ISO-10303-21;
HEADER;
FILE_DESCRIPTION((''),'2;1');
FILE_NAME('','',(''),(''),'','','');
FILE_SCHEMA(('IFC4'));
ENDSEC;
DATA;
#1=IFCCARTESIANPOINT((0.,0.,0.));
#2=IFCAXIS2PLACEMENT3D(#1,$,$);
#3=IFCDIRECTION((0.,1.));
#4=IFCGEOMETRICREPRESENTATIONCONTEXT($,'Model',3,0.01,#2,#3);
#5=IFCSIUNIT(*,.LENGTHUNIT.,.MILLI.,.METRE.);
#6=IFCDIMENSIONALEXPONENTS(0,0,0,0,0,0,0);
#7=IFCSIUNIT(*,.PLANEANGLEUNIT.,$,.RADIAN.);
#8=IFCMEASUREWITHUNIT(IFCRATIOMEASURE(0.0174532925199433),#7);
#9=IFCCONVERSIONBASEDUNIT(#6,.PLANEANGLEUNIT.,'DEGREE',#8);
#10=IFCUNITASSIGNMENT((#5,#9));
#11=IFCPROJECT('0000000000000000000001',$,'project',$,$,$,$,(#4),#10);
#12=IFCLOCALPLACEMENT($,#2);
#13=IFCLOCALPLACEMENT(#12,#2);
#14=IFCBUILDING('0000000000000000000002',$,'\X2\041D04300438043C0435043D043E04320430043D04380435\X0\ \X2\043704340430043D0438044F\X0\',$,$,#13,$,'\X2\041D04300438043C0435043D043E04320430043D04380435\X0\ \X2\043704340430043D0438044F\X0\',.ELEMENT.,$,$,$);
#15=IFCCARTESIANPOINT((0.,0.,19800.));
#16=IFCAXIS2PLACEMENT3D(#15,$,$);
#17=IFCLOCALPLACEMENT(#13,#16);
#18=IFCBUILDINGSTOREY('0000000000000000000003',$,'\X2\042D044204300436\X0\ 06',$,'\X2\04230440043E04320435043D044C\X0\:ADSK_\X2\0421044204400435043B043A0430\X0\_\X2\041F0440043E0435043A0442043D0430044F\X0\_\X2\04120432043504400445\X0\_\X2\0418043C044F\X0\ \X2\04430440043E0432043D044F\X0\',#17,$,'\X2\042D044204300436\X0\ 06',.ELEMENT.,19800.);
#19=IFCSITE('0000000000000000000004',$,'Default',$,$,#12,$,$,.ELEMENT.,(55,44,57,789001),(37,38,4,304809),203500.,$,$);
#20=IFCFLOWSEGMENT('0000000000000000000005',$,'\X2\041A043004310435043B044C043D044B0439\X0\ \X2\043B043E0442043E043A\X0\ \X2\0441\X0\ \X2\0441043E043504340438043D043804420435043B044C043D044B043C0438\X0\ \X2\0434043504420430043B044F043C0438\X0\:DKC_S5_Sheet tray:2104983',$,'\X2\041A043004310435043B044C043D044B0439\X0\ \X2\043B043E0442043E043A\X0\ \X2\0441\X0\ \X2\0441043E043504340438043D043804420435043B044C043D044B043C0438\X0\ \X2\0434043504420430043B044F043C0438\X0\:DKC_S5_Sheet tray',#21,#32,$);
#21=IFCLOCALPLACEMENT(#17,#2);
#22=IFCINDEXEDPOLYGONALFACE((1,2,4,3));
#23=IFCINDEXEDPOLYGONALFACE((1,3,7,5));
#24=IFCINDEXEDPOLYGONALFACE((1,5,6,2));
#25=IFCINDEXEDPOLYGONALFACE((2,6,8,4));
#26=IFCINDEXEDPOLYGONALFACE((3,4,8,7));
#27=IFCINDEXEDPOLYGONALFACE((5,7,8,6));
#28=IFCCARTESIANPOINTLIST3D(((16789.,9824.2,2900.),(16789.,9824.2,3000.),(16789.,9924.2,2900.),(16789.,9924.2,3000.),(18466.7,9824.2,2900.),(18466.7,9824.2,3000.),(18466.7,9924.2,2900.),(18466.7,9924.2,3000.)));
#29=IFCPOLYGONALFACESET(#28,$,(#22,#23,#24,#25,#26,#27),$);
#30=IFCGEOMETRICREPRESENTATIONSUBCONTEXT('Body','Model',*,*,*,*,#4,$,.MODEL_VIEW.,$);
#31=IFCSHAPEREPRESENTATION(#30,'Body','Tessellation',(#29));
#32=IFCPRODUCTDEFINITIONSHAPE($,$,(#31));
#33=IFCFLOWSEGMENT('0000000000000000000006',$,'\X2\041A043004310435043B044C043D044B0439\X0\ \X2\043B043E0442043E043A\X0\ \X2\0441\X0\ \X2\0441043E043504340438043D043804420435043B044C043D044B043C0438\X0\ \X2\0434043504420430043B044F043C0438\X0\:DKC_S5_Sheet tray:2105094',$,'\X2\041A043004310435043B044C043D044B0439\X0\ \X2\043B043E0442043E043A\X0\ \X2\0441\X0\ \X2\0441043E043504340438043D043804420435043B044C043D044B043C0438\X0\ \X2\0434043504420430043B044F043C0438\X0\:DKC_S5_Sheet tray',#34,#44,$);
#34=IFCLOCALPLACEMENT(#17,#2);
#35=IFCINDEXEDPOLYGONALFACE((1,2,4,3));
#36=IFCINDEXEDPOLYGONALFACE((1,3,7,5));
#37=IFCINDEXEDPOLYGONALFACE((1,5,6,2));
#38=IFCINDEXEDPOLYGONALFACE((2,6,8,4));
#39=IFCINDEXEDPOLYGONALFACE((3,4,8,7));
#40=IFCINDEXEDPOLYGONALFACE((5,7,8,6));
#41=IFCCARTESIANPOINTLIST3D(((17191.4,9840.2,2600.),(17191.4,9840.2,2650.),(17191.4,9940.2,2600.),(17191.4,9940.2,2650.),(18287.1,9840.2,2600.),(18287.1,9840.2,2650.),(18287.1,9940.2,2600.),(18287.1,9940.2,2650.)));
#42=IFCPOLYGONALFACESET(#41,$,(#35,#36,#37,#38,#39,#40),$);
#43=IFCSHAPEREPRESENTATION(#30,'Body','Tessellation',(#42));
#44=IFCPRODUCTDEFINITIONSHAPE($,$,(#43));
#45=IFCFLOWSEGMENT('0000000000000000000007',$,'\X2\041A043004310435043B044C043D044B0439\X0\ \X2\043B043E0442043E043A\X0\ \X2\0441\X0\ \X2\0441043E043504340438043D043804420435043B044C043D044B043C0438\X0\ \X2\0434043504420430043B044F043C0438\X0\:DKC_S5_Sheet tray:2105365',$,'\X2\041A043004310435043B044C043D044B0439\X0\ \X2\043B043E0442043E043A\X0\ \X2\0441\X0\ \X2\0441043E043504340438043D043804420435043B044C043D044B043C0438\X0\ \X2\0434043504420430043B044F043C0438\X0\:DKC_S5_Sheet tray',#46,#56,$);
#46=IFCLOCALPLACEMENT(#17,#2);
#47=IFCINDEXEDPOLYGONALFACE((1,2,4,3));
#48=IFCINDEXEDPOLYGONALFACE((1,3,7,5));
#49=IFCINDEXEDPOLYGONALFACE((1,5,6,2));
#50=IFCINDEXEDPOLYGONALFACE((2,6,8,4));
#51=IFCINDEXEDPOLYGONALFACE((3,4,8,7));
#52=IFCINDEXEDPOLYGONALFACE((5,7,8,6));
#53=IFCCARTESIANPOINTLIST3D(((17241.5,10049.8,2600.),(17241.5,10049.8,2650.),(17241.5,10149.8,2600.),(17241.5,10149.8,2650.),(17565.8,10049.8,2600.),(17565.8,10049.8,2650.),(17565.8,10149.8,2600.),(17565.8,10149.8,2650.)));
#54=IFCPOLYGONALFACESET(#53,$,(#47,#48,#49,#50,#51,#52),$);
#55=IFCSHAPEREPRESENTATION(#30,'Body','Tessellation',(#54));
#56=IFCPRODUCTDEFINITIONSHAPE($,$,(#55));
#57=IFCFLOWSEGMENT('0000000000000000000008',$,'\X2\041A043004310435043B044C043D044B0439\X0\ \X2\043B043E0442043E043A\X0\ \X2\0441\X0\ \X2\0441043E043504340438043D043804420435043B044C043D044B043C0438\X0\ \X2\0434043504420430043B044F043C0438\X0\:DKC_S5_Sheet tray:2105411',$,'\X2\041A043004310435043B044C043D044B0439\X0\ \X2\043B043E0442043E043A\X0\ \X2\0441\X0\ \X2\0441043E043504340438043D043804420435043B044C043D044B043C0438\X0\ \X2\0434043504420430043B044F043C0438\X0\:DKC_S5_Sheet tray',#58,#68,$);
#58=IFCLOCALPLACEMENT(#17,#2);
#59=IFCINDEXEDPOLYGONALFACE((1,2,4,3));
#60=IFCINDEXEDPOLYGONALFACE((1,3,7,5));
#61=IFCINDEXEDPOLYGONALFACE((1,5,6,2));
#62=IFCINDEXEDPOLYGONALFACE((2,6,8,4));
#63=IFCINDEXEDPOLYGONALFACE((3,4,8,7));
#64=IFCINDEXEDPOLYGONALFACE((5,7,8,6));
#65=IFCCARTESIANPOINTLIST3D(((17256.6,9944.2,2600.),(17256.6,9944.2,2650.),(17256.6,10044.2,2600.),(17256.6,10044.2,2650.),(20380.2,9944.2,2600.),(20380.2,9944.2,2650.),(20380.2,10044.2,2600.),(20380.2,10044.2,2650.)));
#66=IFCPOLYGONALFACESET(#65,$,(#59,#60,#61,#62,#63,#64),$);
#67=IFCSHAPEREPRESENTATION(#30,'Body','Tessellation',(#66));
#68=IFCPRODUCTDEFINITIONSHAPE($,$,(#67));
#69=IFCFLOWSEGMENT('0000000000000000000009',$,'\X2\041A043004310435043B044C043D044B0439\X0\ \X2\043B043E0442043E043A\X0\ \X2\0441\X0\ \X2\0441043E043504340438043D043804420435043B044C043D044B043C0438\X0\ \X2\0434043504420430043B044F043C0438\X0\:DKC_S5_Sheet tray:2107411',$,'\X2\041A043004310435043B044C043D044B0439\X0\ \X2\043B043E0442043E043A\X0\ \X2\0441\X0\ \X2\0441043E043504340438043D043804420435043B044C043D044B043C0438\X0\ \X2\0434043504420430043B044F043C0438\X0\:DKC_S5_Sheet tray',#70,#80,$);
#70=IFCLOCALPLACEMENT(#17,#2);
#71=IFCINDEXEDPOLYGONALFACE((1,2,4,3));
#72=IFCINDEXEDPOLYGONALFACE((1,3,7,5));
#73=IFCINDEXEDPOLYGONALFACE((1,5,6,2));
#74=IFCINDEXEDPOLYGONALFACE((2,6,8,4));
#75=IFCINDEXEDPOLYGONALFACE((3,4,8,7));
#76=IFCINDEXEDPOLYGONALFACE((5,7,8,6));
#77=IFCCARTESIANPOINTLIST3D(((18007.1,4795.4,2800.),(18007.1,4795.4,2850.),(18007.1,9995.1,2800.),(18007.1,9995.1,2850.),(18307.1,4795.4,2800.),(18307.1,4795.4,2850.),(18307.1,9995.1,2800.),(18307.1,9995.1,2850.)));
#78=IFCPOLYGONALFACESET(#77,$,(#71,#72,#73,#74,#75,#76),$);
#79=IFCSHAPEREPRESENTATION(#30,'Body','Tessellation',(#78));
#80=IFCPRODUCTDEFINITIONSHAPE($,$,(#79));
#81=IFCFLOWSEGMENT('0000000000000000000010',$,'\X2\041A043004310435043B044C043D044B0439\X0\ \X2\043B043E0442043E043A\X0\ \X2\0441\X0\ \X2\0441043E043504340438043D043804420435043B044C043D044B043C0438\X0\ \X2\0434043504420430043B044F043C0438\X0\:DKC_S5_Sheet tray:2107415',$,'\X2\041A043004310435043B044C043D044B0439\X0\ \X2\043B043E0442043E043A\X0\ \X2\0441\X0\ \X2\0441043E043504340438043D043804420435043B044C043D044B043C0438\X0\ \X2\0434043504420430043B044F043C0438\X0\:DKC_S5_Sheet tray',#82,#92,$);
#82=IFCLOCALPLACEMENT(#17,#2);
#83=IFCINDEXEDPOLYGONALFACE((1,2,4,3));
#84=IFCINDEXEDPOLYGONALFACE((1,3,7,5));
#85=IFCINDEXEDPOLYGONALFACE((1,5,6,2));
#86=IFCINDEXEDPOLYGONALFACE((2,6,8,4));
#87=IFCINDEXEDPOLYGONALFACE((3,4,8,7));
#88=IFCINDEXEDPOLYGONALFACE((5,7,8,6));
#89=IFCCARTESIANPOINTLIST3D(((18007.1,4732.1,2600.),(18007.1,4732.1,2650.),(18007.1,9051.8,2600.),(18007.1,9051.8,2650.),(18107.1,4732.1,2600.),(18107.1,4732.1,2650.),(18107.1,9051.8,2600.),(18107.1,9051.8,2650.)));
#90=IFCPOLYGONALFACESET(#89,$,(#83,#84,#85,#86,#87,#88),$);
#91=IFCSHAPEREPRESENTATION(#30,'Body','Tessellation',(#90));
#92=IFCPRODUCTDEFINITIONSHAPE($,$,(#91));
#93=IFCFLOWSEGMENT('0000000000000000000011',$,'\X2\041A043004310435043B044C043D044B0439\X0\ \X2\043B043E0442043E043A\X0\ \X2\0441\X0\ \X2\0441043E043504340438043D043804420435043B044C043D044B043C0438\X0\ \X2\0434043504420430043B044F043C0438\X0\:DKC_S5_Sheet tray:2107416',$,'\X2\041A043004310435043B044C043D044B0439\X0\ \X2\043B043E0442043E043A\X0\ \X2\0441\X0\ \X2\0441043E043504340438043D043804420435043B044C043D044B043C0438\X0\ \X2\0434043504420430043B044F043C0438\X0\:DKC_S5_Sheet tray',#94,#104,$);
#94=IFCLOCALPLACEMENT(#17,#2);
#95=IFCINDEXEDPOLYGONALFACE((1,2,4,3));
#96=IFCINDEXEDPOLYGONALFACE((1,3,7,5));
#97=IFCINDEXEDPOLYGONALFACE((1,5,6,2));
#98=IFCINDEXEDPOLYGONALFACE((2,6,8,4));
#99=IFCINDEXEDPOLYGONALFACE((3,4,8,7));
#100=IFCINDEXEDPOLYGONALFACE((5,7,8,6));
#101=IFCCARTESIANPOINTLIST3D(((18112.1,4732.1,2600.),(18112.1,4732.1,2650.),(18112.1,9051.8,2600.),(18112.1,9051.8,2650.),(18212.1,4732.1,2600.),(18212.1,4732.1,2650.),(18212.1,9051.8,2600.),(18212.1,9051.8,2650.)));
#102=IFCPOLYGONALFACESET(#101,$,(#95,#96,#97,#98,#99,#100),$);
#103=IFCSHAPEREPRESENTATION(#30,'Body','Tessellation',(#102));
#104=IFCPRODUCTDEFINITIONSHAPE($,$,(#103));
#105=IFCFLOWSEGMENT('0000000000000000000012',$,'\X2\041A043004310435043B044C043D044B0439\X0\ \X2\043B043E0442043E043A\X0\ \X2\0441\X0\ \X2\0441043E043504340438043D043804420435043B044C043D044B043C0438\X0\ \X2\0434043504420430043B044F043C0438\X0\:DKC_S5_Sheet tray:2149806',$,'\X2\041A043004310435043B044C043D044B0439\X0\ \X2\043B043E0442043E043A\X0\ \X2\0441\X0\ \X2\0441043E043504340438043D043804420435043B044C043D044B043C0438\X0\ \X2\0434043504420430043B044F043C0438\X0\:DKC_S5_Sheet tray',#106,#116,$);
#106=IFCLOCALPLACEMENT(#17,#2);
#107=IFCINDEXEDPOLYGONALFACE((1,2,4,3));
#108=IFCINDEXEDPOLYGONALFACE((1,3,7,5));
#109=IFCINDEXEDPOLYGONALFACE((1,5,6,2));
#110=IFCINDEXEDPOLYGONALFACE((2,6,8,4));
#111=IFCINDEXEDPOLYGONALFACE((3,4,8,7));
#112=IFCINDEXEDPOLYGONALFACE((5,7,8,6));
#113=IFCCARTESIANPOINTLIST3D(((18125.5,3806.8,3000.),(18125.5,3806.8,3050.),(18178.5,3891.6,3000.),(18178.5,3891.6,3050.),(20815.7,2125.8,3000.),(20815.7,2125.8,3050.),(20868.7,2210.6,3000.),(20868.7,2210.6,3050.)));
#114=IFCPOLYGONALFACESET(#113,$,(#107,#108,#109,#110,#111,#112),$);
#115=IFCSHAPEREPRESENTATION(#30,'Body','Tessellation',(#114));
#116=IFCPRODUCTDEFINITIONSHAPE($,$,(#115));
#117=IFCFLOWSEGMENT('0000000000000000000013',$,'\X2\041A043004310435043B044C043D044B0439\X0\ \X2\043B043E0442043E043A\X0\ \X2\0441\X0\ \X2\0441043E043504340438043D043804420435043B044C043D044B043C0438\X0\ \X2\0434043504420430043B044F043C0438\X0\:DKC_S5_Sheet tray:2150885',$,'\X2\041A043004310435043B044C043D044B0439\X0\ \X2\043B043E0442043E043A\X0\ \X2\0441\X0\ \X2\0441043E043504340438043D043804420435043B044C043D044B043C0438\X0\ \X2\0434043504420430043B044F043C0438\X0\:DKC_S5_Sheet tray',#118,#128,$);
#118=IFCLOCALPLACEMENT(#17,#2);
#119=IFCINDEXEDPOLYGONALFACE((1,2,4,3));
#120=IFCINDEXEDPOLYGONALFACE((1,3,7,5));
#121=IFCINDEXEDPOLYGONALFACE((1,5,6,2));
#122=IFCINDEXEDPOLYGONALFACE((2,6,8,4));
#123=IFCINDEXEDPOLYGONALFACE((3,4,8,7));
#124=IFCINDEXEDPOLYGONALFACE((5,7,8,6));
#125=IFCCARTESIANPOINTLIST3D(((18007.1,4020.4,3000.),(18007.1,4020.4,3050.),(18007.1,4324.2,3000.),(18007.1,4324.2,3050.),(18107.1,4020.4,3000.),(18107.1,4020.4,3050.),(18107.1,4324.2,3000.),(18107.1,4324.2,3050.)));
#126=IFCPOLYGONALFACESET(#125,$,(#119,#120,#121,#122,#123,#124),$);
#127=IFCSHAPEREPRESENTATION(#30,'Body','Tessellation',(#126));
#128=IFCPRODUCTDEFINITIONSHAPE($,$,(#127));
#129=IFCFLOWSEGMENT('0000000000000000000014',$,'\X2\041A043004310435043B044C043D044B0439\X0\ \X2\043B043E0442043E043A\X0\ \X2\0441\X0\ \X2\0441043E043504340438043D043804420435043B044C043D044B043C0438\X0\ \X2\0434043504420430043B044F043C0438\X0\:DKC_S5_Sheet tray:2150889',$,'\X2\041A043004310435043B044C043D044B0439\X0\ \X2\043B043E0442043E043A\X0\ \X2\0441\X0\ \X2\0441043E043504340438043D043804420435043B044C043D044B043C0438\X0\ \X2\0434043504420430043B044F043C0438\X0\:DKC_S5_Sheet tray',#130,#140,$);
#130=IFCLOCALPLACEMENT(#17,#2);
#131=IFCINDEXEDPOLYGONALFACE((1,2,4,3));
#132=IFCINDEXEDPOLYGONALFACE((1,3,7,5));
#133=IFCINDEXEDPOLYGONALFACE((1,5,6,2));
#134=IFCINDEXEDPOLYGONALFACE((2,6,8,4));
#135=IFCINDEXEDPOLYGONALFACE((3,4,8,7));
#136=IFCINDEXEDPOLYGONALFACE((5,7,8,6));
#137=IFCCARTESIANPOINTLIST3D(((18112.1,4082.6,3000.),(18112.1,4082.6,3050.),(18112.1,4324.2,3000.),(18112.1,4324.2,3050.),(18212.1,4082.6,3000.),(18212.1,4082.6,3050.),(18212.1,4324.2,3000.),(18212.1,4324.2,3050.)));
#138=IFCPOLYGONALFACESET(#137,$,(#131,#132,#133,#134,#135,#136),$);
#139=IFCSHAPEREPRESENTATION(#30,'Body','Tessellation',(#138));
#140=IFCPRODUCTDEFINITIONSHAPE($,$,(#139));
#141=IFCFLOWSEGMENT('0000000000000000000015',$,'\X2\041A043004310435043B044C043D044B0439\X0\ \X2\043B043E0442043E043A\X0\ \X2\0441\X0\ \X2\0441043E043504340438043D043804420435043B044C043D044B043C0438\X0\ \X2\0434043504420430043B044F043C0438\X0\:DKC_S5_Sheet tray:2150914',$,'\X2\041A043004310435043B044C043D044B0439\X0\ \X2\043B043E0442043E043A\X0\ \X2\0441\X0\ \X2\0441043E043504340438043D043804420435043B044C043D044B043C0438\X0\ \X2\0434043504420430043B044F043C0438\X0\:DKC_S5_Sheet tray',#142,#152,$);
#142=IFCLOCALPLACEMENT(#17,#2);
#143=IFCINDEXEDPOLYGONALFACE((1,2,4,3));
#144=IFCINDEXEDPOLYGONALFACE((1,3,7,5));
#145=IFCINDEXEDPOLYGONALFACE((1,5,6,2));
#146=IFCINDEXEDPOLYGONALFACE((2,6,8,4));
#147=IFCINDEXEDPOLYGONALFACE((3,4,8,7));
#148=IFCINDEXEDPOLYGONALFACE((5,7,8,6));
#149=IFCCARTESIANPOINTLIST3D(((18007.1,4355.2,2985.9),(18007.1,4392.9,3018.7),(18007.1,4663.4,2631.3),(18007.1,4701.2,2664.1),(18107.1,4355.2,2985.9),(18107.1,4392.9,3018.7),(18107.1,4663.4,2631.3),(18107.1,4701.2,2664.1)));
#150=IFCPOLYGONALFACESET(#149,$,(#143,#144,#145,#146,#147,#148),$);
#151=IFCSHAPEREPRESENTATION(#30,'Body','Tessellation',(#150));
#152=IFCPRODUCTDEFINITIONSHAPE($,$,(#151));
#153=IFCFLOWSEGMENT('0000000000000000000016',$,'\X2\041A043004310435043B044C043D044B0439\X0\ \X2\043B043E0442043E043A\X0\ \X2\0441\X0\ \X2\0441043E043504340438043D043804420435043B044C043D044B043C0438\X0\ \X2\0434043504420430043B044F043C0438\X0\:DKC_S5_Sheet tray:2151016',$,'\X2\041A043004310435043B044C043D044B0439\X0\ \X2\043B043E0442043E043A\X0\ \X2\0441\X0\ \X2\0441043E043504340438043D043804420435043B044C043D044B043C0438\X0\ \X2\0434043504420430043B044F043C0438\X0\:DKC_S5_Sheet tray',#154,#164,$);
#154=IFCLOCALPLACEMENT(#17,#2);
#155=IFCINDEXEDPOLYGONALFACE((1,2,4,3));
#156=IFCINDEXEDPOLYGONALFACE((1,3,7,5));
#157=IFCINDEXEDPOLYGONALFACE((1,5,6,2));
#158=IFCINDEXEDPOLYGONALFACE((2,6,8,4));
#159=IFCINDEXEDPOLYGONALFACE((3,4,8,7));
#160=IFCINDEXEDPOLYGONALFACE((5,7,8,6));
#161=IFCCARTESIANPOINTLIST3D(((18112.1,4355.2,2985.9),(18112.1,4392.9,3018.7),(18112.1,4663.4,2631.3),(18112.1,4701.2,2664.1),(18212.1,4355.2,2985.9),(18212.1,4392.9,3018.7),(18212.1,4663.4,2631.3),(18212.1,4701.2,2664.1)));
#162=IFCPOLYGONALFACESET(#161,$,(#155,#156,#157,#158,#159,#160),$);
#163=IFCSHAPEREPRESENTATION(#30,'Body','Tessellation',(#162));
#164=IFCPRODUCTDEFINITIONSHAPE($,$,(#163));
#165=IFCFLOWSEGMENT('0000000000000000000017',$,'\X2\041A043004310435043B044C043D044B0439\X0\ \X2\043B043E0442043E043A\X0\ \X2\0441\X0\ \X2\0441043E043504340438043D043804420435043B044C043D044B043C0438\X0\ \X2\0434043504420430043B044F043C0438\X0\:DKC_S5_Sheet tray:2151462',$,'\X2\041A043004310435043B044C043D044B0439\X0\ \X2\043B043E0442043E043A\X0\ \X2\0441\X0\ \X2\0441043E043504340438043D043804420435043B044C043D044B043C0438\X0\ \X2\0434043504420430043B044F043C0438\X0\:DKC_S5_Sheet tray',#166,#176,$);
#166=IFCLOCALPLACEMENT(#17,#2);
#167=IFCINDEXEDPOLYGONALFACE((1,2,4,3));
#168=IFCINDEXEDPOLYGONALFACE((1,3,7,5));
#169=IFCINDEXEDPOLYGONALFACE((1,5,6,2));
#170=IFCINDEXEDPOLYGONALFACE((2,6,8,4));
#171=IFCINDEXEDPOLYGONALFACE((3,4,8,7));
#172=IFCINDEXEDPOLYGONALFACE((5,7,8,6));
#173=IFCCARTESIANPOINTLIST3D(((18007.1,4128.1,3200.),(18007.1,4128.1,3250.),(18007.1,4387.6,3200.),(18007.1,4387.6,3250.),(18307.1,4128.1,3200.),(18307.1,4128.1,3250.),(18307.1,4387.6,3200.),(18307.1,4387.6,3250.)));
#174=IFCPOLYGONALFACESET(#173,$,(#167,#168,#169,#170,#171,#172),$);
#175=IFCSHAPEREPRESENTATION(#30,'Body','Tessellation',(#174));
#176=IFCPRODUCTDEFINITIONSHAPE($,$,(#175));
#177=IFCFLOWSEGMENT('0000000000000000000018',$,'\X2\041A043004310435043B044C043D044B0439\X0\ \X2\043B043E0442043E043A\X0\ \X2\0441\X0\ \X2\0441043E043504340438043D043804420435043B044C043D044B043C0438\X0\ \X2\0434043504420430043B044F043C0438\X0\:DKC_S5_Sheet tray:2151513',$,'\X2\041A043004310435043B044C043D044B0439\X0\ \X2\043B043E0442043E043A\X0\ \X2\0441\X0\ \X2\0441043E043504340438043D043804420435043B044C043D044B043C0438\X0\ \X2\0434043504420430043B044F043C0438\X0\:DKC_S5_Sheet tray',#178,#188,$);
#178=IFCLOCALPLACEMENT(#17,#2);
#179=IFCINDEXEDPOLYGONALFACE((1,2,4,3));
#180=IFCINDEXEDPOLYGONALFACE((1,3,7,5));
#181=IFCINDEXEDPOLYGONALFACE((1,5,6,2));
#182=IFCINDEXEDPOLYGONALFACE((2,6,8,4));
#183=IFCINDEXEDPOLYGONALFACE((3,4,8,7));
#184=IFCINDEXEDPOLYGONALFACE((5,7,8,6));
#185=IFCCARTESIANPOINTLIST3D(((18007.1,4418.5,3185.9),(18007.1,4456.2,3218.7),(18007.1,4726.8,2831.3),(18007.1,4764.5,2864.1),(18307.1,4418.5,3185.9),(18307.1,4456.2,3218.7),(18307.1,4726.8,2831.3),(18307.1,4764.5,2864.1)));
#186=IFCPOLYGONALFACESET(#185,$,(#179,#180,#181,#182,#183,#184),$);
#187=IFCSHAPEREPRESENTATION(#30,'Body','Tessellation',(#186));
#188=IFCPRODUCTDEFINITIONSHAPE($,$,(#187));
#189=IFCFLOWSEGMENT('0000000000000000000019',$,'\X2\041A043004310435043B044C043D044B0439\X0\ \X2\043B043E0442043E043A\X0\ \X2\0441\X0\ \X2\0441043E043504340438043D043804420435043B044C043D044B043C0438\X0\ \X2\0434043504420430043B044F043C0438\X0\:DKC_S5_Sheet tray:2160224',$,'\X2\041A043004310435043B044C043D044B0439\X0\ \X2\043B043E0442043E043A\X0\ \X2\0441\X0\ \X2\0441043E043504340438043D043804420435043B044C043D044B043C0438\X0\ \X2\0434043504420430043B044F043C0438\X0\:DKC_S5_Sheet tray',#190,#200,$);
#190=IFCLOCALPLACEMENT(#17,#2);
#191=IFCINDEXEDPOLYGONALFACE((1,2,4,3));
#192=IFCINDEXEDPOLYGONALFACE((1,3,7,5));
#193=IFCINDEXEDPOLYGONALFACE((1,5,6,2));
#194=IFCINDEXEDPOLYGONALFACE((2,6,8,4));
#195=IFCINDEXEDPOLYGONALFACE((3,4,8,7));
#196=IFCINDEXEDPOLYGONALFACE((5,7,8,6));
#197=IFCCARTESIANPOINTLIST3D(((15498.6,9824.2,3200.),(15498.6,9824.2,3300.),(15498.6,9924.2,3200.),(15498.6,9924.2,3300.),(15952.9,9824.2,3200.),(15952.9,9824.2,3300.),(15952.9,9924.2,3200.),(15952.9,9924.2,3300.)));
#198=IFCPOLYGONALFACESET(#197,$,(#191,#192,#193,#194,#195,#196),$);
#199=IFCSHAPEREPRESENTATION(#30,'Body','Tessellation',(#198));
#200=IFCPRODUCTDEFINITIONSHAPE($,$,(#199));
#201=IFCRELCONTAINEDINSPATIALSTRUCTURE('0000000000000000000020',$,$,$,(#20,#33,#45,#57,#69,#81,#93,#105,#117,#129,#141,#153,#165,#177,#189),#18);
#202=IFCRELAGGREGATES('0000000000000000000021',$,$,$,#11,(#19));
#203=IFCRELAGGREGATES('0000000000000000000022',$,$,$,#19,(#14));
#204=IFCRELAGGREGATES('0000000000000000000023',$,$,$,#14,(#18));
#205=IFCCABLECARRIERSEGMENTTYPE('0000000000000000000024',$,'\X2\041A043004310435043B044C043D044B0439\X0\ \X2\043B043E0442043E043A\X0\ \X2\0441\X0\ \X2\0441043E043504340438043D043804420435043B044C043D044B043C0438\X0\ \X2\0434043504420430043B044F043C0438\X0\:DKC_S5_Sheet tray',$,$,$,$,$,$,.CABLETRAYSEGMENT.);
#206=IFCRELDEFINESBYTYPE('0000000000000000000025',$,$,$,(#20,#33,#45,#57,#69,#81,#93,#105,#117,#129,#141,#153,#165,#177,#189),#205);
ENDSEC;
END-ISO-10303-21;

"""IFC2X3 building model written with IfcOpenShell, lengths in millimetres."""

from ifc_helpers import new_model, entity, si_unit, converted_unit, direction, frame, origin, origin_2d_with_axis, place, context, subcontext, project, spatial, rectangle, extrude, type_object, element, save


model = new_model("IFC2X3")

# Units and contexts
model_context = context("Model", 3, precision=0.01, world=origin(), true_north=direction((0.0, 1.0)))
body_context = subcontext(model_context, "Body", "Model", "MODEL_VIEW")
ifc_project = project(units=[si_unit("LENGTHUNIT", "METRE", prefix="MILLI"), converted_unit("PLANEANGLEUNIT", "DEGREE", entity("IfcRatioMeasure", 0.0174532925199433), si_unit("PLANEANGLEUNIT", "RADIAN"), dimensions=[0, 0, 0, 0, 0, 0, 0])], contexts=[model_context])

# Site, building, storey
site_placement = place(None, origin())
site = spatial("IfcSite", under=ifc_project, at=site_placement, Name="Default", CompositionType="ELEMENT", RefLatitude=(55, 44, 57, 789001), RefLongitude=(37, 38, 4, 304809), RefElevation=203500.0)
building_placement = place(site_placement, origin())
building = spatial("IfcBuilding", under=site, at=building_placement, Name="Наименование здания", LongName="Наименование здания", CompositionType="ELEMENT")
storey_placement = place(building_placement, frame((0.0, 0.0, 19800.0)))
storey = spatial("IfcBuildingStorey", under=building, at=storey_placement, Name="Этаж 06", ObjectType="Уровень:ADSK_Стрелка_Проектная_Вверх_Имя уровня", LongName="Этаж 06", CompositionType="ELEMENT", Elevation=19800.0)

# Flow segments
cable_carrier_segment_type = type_object("IfcCableCarrierSegmentType", Name="Кабельный лоток с соединительными деталями:DKC_S5_Sheet tray", PredefinedType="CABLETRAYSEGMENT")
flow_segment_1_placement = place(storey_placement, frame((16789.0, 9824.2, 2900.0)))
element("IfcFlowSegment", 1, at=flow_segment_1_placement, inside=storey, type_object=cable_carrier_segment_type, Name="Кабельный лоток с соединительными деталями:DKC_S5_Sheet tray:2104983", ObjectType="Кабельный лоток с соединительными деталями:DKC_S5_Sheet tray", context=body_context, shape_type="SweptSolid", body=[
    extrude(rectangle(XDim=1677.7, YDim=100.0, at=origin_2d_with_axis()), frame((838.9, 50.0, 0.0)), (0.0, 0.0, 1.0), 100.0),
])
flow_segment_2_placement = place(storey_placement, frame((17191.3, 9840.2, 2600.0)))
element("IfcFlowSegment", 2, at=flow_segment_2_placement, inside=storey, type_object=cable_carrier_segment_type, Name="Кабельный лоток с соединительными деталями:DKC_S5_Sheet tray:2105094", ObjectType="Кабельный лоток с соединительными деталями:DKC_S5_Sheet tray", context=body_context, shape_type="SweptSolid", body=[
    extrude(rectangle(XDim=1095.8, YDim=100.0, at=origin_2d_with_axis()), frame((547.9, 50.0, 0.0)), (0.0, 0.0, 1.0), 50.0),
])
flow_segment_3_placement = place(storey_placement, frame((17241.5, 10049.8, 2600.0)))
element("IfcFlowSegment", 3, at=flow_segment_3_placement, inside=storey, type_object=cable_carrier_segment_type, Name="Кабельный лоток с соединительными деталями:DKC_S5_Sheet tray:2105365", ObjectType="Кабельный лоток с соединительными деталями:DKC_S5_Sheet tray", context=body_context, shape_type="SweptSolid", body=[
    extrude(rectangle(XDim=324.4, YDim=100.0, at=origin_2d_with_axis()), frame((162.2, 50.0, 0.0), z_axis=(0.0, 0.0, 1.0), x_axis=(-1.0, 0.0, 0.0)), (0.0, 0.0, 1.0), 50.0),
])
flow_segment_4_placement = place(storey_placement, frame((17256.6, 9944.2, 2600.0)))
element("IfcFlowSegment", 4, at=flow_segment_4_placement, inside=storey, type_object=cable_carrier_segment_type, Name="Кабельный лоток с соединительными деталями:DKC_S5_Sheet tray:2105411", ObjectType="Кабельный лоток с соединительными деталями:DKC_S5_Sheet tray", context=body_context, shape_type="SweptSolid", body=[
    extrude(rectangle(XDim=3123.6, YDim=100.0, at=origin_2d_with_axis()), frame((1561.8, 50.0, 0.0), z_axis=(0.0, 0.0, 1.0), x_axis=(-1.0, 0.0, 0.0)), (0.0, 0.0, 1.0), 50.0),
])
flow_segment_5_placement = place(storey_placement, frame((18007.1, 4795.4, 2800.0)))
element("IfcFlowSegment", 5, at=flow_segment_5_placement, inside=storey, type_object=cable_carrier_segment_type, Name="Кабельный лоток с соединительными деталями:DKC_S5_Sheet tray:2107411", ObjectType="Кабельный лоток с соединительными деталями:DKC_S5_Sheet tray", context=body_context, shape_type="SweptSolid", body=[
    extrude(rectangle(XDim=5199.7, YDim=300.0, at=origin_2d_with_axis()), frame((150.0, 2599.9, 0.0), z_axis=(0.0, 0.0, 1.0), x_axis=(0.0, 1.0, 0.0)), (0.0, 0.0, 1.0), 50.0),
])
flow_segment_6_placement = place(storey_placement, frame((18007.1, 4732.1, 2600.0)))
element("IfcFlowSegment", 6, at=flow_segment_6_placement, inside=storey, type_object=cable_carrier_segment_type, Name="Кабельный лоток с соединительными деталями:DKC_S5_Sheet tray:2107415", ObjectType="Кабельный лоток с соединительными деталями:DKC_S5_Sheet tray", context=body_context, shape_type="SweptSolid", body=[
    extrude(rectangle(XDim=4319.7, YDim=100.0, at=origin_2d_with_axis()), frame((50.0, 2159.8, 0.0), z_axis=(0.0, 0.0, 1.0), x_axis=(0.0, 1.0, 0.0)), (0.0, 0.0, 1.0), 50.0),
])
flow_segment_7_placement = place(storey_placement, frame((18112.1, 4732.1, 2600.0)))
element("IfcFlowSegment", 7, at=flow_segment_7_placement, inside=storey, type_object=cable_carrier_segment_type, Name="Кабельный лоток с соединительными деталями:DKC_S5_Sheet tray:2107416", ObjectType="Кабельный лоток с соединительными деталями:DKC_S5_Sheet tray", context=body_context, shape_type="SweptSolid", body=[
    extrude(rectangle(XDim=4319.7, YDim=100.0, at=origin_2d_with_axis()), frame((50.0, 2159.8, 0.0), z_axis=(0.0, 0.0, 1.0), x_axis=(0.0, 1.0, 0.0)), (0.0, 0.0, 1.0), 50.0),
])
flow_segment_8_placement = place(storey_placement, frame((18125.5, 2125.8, 3000.0)))
element("IfcFlowSegment", 8, at=flow_segment_8_placement, inside=storey, type_object=cable_carrier_segment_type, Name="Кабельный лоток с соединительными деталями:DKC_S5_Sheet tray:2149806", ObjectType="Кабельный лоток с соединительными деталями:DKC_S5_Sheet tray", context=body_context, shape_type="SweptSolid", body=[
    extrude(rectangle(XDim=3172.2, YDim=100.0, at=origin_2d_with_axis()), frame((1371.6, 882.9, 0.0), z_axis=(0.0, 0.0, 1.0), x_axis=(-0.848048, 0.529919, 0.0)), (0.0, 0.0, 1.0), 50.0),
])
flow_segment_9_placement = place(storey_placement, frame((18007.1, 4020.3, 3000.0)))
element("IfcFlowSegment", 9, at=flow_segment_9_placement, inside=storey, type_object=cable_carrier_segment_type, Name="Кабельный лоток с соединительными деталями:DKC_S5_Sheet tray:2150885", ObjectType="Кабельный лоток с соединительными деталями:DKC_S5_Sheet tray", context=body_context, shape_type="SweptSolid", body=[
    extrude(rectangle(XDim=303.9, YDim=100.0, at=origin_2d_with_axis()), frame((50.0, 151.9, 0.0), z_axis=(0.0, 0.0, 1.0), x_axis=(0.0, 1.0, 0.0)), (0.0, 0.0, 1.0), 50.0),
])
flow_segment_10_placement = place(storey_placement, frame((18112.1, 4082.6, 3000.0)))
element("IfcFlowSegment", 10, at=flow_segment_10_placement, inside=storey, type_object=cable_carrier_segment_type, Name="Кабельный лоток с соединительными деталями:DKC_S5_Sheet tray:2150889", ObjectType="Кабельный лоток с соединительными деталями:DKC_S5_Sheet tray", context=body_context, shape_type="SweptSolid", body=[
    extrude(rectangle(XDim=241.6, YDim=100.0, at=origin_2d_with_axis()), frame((50.0, 120.8, 0.0), z_axis=(0.0, 0.0, 1.0), x_axis=(0.0, 1.0, 0.0)), (0.0, 0.0, 1.0), 50.0),
])
for number, where, name in (
    (11, (18007.1, 4355.2, 2631.3), "Кабельный лоток с соединительными деталями:DKC_S5_Sheet tray:2150914"),
    (12, (18112.1, 4355.2, 2631.3), "Кабельный лоток с соединительными деталями:DKC_S5_Sheet tray:2151016"),
):
    element("IfcFlowSegment", number, at=place(storey_placement, frame(where)), inside=storey, type_object=cable_carrier_segment_type, Name=name, ObjectType="Кабельный лоток с соединительными деталями:DKC_S5_Sheet tray", context=body_context, shape_type="SweptSolid", body=[
        extrude(rectangle(XDim=50.0, YDim=100.0, at=origin_2d_with_axis()), frame((50.0, 327.1, 16.4), z_axis=(0.0, -0.656059, 0.75471), x_axis=(0.0, 0.75471, 0.656059)), (0.0, 0.0, 1.0), 469.9),
    ])
flow_segment_11_placement = place(storey_placement, frame((18007.1, 4128.1, 3200.0)))
element("IfcFlowSegment", 13, at=flow_segment_11_placement, inside=storey, type_object=cable_carrier_segment_type, Name="Кабельный лоток с соединительными деталями:DKC_S5_Sheet tray:2151462", ObjectType="Кабельный лоток с соединительными деталями:DKC_S5_Sheet tray", context=body_context, shape_type="SweptSolid", body=[
    extrude(rectangle(XDim=259.5, YDim=300.0, at=origin_2d_with_axis()), frame((150.0, 129.8, 0.0), z_axis=(0.0, 0.0, 1.0), x_axis=(0.0, 1.0, 0.0)), (0.0, 0.0, 1.0), 50.0),
])
flow_segment_12_placement = place(storey_placement, frame((18007.1, 4418.5, 2831.3)))
element("IfcFlowSegment", 14, at=flow_segment_12_placement, inside=storey, type_object=cable_carrier_segment_type, Name="Кабельный лоток с соединительными деталями:DKC_S5_Sheet tray:2151513", ObjectType="Кабельный лоток с соединительными деталями:DKC_S5_Sheet tray", context=body_context, shape_type="SweptSolid", body=[
    extrude(rectangle(XDim=50.0, YDim=300.0, at=origin_2d_with_axis()), frame((150.0, 327.1, 16.4), z_axis=(0.0, -0.656059, 0.75471), x_axis=(0.0, 0.75471, 0.656059)), (0.0, 0.0, 1.0), 469.9),
])
flow_segment_13_placement = place(storey_placement, frame((15498.6, 9824.2, 3200.0)))
element("IfcFlowSegment", 15, at=flow_segment_13_placement, inside=storey, type_object=cable_carrier_segment_type, Name="Кабельный лоток с соединительными деталями:DKC_S5_Sheet tray:2160224", ObjectType="Кабельный лоток с соединительными деталями:DKC_S5_Sheet tray", context=body_context, shape_type="SweptSolid", body=[
    extrude(rectangle(XDim=454.3, YDim=100.0, at=origin_2d_with_axis()), frame((227.1, 50.0, 0.0), z_axis=(0.0, 0.0, 1.0), x_axis=(-1.0, 0.0, 0.0)), (0.0, 0.0, 1.0), 100.0),
])

save(model, "model.ifc")
